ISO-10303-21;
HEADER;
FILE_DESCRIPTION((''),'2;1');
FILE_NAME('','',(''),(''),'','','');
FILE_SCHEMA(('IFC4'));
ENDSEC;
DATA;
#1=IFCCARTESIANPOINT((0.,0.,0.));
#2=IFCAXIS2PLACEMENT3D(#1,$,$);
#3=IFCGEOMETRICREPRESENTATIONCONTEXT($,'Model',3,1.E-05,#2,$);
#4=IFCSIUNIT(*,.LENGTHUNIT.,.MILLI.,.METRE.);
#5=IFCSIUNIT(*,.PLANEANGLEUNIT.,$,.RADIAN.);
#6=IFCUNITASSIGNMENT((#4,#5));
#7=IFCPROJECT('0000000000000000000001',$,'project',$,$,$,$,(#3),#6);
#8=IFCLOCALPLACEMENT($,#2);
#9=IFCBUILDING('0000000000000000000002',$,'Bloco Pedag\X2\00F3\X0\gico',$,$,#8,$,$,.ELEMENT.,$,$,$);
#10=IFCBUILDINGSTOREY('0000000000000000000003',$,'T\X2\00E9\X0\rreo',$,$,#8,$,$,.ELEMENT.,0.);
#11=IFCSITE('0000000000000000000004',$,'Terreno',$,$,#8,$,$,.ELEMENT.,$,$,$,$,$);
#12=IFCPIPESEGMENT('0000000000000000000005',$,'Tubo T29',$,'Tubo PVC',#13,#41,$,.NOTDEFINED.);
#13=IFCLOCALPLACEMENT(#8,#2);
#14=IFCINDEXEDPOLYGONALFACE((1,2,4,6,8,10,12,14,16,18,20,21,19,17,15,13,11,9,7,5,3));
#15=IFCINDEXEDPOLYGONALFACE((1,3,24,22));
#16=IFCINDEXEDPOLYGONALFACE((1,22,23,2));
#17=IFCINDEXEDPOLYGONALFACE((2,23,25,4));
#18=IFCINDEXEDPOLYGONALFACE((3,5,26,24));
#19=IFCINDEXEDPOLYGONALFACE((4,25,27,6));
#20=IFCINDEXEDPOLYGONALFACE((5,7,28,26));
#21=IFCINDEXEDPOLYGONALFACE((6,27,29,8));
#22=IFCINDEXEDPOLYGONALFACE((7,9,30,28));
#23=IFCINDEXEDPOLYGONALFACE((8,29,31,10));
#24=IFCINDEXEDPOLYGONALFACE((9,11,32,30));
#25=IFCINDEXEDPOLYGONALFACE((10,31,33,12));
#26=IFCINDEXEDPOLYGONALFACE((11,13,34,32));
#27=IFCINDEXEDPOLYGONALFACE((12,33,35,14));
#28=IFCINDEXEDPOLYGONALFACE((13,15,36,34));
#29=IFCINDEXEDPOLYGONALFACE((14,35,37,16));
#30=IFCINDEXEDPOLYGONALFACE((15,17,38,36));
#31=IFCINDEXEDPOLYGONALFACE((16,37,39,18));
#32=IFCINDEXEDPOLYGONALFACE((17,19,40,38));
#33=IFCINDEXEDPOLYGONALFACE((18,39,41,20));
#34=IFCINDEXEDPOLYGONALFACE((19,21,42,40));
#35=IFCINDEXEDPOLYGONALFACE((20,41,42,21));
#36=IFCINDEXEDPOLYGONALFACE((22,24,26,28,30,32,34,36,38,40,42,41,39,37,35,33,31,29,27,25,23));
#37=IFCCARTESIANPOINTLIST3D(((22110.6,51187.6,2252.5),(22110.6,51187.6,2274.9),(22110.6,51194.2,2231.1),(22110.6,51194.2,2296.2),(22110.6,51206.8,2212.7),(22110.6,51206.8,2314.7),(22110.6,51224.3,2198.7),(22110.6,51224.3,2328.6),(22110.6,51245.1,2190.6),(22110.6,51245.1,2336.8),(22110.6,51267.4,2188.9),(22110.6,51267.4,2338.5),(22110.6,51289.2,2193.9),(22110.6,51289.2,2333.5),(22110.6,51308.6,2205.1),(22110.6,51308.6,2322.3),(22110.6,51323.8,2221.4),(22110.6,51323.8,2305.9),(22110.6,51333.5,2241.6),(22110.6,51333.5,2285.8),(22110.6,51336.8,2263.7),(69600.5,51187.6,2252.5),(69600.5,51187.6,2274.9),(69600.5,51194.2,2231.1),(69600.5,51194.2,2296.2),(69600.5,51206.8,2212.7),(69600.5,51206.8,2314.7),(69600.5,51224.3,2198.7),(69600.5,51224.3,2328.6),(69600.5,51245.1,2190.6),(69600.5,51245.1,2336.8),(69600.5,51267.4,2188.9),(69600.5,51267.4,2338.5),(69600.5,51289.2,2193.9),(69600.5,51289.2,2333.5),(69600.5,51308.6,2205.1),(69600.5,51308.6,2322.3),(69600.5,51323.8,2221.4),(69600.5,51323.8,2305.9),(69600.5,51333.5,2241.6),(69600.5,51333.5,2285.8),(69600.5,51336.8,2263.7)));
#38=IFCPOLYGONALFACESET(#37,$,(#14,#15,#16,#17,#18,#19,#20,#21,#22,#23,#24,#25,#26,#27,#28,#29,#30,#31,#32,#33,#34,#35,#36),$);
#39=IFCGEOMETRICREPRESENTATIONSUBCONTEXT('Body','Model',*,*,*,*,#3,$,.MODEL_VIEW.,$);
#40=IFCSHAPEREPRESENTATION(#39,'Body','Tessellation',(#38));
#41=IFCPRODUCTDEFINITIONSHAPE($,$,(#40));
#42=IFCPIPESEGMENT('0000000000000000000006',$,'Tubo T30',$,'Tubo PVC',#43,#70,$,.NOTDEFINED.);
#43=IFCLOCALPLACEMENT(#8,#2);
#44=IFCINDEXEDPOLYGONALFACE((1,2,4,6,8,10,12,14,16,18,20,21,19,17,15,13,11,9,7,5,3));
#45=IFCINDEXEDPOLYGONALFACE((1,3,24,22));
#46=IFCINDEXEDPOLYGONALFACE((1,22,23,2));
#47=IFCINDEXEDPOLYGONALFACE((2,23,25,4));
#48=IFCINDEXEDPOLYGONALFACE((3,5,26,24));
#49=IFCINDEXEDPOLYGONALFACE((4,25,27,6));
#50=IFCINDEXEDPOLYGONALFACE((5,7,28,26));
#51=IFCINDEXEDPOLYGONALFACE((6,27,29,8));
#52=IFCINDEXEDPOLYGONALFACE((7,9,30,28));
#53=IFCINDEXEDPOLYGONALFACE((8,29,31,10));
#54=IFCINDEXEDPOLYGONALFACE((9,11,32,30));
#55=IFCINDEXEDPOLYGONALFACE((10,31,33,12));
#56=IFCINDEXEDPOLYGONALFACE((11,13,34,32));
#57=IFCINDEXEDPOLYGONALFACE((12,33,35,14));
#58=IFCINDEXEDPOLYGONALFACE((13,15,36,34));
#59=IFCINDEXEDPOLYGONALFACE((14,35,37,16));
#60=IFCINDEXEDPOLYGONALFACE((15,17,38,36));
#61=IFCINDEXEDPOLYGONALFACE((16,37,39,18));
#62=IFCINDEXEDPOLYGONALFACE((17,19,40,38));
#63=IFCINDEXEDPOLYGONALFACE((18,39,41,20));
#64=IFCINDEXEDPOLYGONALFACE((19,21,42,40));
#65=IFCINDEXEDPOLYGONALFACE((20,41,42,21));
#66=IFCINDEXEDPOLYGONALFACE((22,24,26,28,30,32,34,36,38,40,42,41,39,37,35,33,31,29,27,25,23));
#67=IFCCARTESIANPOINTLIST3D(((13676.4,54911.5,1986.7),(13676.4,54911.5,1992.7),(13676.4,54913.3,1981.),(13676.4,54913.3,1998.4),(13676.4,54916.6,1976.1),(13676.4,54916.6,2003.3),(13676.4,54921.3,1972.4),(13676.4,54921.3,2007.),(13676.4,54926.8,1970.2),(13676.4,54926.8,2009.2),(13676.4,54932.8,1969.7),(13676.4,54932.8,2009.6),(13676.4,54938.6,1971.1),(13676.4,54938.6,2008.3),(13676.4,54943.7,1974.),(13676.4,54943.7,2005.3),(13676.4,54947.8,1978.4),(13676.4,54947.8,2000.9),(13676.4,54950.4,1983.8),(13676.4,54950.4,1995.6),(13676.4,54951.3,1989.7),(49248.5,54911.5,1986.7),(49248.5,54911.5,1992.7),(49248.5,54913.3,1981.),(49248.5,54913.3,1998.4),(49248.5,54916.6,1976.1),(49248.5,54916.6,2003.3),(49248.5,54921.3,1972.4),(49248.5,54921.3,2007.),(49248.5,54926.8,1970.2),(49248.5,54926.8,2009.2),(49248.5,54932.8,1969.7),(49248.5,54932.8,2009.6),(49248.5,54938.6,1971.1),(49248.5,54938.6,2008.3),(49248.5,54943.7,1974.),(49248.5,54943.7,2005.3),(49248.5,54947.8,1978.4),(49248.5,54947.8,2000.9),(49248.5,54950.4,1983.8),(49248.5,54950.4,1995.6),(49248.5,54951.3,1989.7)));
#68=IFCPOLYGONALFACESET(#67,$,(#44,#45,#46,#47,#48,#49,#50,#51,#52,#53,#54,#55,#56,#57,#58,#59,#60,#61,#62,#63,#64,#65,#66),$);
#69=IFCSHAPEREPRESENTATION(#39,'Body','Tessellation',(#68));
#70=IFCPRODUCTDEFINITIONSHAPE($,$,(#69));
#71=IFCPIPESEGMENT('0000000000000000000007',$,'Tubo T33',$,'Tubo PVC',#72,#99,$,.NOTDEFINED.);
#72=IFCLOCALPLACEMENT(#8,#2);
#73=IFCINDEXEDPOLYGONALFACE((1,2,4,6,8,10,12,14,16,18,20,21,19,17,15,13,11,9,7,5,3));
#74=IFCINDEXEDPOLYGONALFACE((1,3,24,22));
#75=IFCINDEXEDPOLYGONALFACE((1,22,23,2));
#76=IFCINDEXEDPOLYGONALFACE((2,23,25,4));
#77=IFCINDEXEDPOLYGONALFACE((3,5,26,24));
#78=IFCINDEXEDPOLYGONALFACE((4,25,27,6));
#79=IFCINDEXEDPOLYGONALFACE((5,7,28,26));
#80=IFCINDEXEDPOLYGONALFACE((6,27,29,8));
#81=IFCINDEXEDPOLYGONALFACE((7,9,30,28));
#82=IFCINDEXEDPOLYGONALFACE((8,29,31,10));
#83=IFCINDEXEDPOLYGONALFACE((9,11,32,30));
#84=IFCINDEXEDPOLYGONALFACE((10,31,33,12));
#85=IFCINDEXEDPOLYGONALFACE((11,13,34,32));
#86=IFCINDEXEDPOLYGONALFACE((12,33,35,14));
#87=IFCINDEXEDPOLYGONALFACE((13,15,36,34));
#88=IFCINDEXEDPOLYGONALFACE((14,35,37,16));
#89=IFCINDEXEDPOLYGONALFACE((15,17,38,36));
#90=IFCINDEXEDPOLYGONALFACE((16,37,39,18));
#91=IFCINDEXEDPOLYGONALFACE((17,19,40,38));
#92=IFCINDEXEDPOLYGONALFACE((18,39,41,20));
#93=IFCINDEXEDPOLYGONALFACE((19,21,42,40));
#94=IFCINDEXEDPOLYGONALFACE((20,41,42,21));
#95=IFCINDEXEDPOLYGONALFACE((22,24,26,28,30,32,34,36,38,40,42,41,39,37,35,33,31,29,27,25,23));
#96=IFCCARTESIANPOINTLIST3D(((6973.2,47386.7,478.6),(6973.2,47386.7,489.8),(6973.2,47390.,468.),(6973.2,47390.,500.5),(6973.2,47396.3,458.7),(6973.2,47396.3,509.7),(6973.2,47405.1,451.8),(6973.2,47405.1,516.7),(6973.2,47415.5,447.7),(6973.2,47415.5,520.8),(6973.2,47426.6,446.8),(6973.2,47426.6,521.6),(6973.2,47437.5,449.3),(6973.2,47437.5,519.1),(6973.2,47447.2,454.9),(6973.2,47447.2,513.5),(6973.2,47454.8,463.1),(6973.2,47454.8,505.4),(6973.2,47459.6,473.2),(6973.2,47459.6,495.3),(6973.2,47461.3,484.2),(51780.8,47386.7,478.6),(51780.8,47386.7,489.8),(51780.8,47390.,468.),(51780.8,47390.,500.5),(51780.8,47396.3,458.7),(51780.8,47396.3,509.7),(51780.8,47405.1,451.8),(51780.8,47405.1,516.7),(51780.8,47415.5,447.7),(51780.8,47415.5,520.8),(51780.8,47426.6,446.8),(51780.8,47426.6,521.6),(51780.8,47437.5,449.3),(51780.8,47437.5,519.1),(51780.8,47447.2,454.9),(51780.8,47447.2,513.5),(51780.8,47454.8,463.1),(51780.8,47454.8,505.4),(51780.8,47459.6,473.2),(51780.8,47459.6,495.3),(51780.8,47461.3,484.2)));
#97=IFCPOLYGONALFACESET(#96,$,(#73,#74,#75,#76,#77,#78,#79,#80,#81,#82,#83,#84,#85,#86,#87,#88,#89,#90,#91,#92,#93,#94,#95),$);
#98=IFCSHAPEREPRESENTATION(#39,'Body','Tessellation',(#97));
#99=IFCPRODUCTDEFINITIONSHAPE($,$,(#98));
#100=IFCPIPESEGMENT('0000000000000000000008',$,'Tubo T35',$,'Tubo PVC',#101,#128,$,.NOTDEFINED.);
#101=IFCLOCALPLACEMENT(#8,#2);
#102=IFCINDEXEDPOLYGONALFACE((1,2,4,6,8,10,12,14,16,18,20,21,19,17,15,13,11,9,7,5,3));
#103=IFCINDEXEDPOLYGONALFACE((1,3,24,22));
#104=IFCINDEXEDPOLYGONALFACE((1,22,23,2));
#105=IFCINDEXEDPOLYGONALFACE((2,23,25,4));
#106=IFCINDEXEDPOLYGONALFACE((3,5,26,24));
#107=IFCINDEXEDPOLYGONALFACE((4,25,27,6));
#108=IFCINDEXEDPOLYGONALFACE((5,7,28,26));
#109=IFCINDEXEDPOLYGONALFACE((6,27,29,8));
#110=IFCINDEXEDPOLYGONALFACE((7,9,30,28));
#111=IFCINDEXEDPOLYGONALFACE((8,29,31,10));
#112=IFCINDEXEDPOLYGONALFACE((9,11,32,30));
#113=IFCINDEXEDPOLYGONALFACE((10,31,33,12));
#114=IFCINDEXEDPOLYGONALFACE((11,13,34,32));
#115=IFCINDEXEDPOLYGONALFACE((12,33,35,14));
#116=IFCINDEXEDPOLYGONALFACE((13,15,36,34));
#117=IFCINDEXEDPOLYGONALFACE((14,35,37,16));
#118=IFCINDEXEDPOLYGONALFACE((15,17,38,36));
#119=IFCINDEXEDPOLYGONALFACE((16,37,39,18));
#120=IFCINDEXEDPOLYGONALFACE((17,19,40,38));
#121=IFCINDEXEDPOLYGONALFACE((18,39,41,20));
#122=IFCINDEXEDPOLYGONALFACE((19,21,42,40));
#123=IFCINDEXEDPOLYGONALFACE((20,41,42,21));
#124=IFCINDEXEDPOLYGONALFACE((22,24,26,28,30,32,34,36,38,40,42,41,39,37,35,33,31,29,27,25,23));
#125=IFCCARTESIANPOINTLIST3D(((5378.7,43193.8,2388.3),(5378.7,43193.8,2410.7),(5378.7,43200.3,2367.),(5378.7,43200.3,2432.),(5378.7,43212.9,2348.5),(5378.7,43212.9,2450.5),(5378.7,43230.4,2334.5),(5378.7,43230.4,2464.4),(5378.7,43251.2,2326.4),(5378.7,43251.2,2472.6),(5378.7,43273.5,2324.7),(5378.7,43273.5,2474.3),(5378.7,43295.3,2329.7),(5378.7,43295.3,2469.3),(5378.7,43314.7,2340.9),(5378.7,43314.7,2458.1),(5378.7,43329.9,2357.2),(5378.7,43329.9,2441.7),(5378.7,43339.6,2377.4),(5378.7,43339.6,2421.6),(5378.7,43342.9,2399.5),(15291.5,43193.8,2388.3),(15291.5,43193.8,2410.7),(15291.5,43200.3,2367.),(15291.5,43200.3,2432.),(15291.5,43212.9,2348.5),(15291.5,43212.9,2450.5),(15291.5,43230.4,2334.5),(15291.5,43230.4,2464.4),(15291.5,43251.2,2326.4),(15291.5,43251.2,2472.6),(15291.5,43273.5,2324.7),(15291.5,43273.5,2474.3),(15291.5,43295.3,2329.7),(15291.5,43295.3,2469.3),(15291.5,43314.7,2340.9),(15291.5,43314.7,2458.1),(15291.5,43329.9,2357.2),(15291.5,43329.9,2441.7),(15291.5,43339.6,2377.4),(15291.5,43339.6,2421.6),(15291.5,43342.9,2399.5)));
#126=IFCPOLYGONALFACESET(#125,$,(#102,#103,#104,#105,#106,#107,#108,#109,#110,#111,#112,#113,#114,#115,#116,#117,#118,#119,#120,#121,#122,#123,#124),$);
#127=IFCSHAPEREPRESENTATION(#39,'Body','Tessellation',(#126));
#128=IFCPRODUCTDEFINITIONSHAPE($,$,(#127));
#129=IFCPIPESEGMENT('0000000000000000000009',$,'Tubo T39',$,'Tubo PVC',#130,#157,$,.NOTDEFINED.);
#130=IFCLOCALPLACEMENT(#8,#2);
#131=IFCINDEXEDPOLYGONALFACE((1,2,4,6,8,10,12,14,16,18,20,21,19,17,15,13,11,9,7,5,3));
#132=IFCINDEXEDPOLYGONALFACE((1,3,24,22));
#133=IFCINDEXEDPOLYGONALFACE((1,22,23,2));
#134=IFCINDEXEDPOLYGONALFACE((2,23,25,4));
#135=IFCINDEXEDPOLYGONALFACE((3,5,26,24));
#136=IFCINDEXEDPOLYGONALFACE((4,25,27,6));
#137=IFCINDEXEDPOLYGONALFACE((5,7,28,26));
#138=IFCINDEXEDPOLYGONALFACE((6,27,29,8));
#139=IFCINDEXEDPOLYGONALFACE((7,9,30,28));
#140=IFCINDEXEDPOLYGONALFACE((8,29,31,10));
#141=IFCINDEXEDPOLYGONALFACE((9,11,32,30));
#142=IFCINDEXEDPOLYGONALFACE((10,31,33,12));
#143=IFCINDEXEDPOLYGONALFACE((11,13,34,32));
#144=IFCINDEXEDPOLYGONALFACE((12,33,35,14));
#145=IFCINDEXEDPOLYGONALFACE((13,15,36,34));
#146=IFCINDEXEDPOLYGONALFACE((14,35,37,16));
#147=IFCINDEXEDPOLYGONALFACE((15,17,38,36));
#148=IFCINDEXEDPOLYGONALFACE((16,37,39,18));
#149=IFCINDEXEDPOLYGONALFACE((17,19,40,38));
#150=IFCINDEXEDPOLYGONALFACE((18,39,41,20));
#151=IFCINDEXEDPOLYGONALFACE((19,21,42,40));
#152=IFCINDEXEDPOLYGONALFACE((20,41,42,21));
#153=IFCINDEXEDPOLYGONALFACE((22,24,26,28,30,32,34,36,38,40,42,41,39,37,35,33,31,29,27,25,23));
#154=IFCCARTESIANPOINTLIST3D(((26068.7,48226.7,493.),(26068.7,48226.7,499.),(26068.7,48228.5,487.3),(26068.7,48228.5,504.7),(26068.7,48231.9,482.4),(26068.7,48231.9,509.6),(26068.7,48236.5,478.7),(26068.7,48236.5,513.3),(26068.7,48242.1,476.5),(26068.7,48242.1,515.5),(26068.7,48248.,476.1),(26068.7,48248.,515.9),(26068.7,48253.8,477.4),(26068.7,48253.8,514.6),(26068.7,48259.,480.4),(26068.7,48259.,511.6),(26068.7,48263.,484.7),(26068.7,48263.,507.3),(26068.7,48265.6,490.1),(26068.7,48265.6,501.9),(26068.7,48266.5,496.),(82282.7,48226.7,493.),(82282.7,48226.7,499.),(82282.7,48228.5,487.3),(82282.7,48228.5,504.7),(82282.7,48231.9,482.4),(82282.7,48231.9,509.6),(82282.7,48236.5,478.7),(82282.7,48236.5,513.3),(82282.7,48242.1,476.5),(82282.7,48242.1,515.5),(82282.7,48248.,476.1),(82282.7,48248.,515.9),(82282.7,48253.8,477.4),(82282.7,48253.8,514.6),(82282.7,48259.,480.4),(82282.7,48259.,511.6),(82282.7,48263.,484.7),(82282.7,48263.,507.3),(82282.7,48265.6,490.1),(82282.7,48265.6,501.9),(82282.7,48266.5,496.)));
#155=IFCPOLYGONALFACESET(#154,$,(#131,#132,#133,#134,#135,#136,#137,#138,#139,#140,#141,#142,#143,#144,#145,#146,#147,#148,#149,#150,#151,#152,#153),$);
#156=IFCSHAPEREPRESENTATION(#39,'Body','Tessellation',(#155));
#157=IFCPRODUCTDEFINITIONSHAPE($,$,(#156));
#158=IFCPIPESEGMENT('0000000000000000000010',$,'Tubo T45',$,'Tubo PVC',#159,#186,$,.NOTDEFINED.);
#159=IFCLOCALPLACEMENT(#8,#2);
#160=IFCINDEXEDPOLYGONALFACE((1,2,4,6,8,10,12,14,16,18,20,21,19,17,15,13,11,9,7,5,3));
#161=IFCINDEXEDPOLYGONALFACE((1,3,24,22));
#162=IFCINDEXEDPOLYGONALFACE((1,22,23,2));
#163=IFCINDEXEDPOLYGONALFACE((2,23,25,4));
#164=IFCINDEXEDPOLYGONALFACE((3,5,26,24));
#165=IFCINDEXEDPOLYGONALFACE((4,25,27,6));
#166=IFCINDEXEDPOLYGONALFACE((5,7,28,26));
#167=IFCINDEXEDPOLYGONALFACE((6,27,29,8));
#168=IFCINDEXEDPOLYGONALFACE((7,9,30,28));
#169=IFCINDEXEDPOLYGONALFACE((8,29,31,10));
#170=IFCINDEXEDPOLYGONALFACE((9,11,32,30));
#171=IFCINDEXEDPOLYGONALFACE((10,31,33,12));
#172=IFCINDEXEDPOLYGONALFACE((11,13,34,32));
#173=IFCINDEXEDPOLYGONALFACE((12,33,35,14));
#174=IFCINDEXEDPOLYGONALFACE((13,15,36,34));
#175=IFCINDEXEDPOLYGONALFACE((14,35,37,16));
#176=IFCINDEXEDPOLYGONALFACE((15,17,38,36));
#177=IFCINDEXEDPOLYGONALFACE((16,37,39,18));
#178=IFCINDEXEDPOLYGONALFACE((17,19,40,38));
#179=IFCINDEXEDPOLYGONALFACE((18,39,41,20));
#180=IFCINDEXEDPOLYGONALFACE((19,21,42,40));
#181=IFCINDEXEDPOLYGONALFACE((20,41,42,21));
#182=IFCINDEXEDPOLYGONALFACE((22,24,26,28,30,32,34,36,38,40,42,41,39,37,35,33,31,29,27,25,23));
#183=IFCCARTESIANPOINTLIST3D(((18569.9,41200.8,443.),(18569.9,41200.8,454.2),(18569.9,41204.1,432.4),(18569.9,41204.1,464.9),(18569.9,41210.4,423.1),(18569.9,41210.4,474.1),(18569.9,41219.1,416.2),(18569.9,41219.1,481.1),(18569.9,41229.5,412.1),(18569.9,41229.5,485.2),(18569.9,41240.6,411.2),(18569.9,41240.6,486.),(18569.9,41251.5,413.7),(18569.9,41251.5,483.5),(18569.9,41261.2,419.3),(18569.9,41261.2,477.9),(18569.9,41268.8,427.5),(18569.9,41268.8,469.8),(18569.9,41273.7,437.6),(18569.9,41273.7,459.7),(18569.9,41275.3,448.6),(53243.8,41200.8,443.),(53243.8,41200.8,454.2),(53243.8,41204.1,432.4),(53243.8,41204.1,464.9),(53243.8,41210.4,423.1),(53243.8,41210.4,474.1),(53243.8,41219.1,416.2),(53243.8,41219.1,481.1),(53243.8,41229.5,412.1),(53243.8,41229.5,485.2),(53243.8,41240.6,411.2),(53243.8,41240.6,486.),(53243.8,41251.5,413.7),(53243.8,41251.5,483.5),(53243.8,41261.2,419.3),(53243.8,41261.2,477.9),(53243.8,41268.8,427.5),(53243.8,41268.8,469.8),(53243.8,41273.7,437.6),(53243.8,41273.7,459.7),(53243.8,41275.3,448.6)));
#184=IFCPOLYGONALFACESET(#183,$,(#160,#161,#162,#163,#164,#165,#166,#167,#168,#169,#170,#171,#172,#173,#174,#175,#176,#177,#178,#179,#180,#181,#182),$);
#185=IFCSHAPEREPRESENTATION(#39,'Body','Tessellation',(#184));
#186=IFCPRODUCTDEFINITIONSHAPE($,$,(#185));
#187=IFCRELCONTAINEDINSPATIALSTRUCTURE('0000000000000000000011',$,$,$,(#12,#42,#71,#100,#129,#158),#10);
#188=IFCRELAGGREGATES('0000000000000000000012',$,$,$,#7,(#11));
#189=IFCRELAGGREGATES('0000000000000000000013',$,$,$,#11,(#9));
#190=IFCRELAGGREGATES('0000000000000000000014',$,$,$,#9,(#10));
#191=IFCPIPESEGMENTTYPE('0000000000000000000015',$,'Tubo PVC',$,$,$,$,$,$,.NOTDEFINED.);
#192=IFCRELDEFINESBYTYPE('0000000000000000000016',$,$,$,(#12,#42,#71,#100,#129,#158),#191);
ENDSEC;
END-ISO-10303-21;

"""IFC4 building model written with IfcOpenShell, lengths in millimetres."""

from ifc_helpers import new_model, si_unit, frame, origin, origin_2d, place, context, subcontext, project, spatial, circle, extrude, type_object, element, save


model = new_model("IFC4")

# Units and contexts
model_context = context("Model", 3, precision=1e-05, world=origin())
body_context = subcontext(model_context, "Body", "Model", "MODEL_VIEW")
ifc_project = project(units=[si_unit("LENGTHUNIT", "METRE", prefix="MILLI"), si_unit("PLANEANGLEUNIT", "RADIAN")], contexts=[model_context])

# Site, building, storey
placement = place(None, origin())
site = spatial("IfcSite", under=ifc_project, at=placement, Name="Terreno", CompositionType="ELEMENT")
building = spatial("IfcBuilding", under=site, at=placement, Name="Bloco Pedagógico", CompositionType="ELEMENT")
storey = spatial("IfcBuildingStorey", under=building, at=placement, Name="Térreo", CompositionType="ELEMENT", Elevation=0.0)

# Pipe segments
pipe_segment_type = type_object("IfcPipeSegmentType", Name="Tubo PVC", PredefinedType="NOTDEFINED")
pipe_segment_1_placement = place(None, frame((22110.6, 51261.8, 2263.7), z_axis=(1.0, 0.0, 0.0), x_axis=(0.0, 1.0, 0.0)))
element("IfcPipeSegment", 1, at=pipe_segment_1_placement, inside=storey, type_object=pipe_segment_type, Name="Tubo T29", ObjectType="Tubo PVC", PredefinedType="NOTDEFINED", context=body_context, shape_type="SweptSolid", body=[
    extrude(circle(Radius=75.0, at=origin_2d()), None, (0.0, 0.0, 1.0), 47489.9),
])
pipe_segment_2_placement = place(None, frame((13676.4, 54931.3, 1989.7), z_axis=(1.0, 0.0, 0.0), x_axis=(0.0, 1.0, 0.0)))
element("IfcPipeSegment", 2, at=pipe_segment_2_placement, inside=storey, type_object=pipe_segment_type, Name="Tubo T30", ObjectType="Tubo PVC", PredefinedType="NOTDEFINED", context=body_context, shape_type="SweptSolid", body=[
    extrude(circle(Radius=20.0, at=origin_2d()), None, (0.0, 0.0, 1.0), 35572.1),
])
pipe_segment_3_placement = place(None, frame((6973.2, 47423.8, 484.2), z_axis=(1.0, 0.0, 0.0), x_axis=(0.0, 1.0, 0.0)))
element("IfcPipeSegment", 3, at=pipe_segment_3_placement, inside=storey, type_object=pipe_segment_type, Name="Tubo T33", ObjectType="Tubo PVC", PredefinedType="NOTDEFINED", context=body_context, shape_type="SweptSolid", body=[
    extrude(circle(Radius=37.5, at=origin_2d()), None, (0.0, 0.0, 1.0), 44807.6),
])
pipe_segment_4_placement = place(None, frame((5378.7, 43267.9, 2399.5), z_axis=(1.0, 0.0, 0.0), x_axis=(0.0, 1.0, 0.0)))
element("IfcPipeSegment", 4, at=pipe_segment_4_placement, inside=storey, type_object=pipe_segment_type, Name="Tubo T35", ObjectType="Tubo PVC", PredefinedType="NOTDEFINED", context=body_context, shape_type="SweptSolid", body=[
    extrude(circle(Radius=75.0, at=origin_2d()), None, (0.0, 0.0, 1.0), 9912.8),
])
pipe_segment_5_placement = place(None, frame((26068.7, 48246.5, 496.0), z_axis=(1.0, 0.0, 0.0), x_axis=(0.0, 1.0, 0.0)))
element("IfcPipeSegment", 5, at=pipe_segment_5_placement, inside=storey, type_object=pipe_segment_type, Name="Tubo T39", ObjectType="Tubo PVC", PredefinedType="NOTDEFINED", context=body_context, shape_type="SweptSolid", body=[
    extrude(circle(Radius=20.0, at=origin_2d()), None, (0.0, 0.0, 1.0), 56214.0),
])
pipe_segment_6_placement = place(None, frame((18569.9, 41237.8, 448.6), z_axis=(1.0, 0.0, 0.0), x_axis=(0.0, 1.0, 0.0)))
element("IfcPipeSegment", 6, at=pipe_segment_6_placement, inside=storey, type_object=pipe_segment_type, Name="Tubo T45", ObjectType="Tubo PVC", PredefinedType="NOTDEFINED", context=body_context, shape_type="SweptSolid", body=[
    extrude(circle(Radius=37.5, at=origin_2d()), None, (0.0, 0.0, 1.0), 34673.9),
])

save(model, "model.ifc")
